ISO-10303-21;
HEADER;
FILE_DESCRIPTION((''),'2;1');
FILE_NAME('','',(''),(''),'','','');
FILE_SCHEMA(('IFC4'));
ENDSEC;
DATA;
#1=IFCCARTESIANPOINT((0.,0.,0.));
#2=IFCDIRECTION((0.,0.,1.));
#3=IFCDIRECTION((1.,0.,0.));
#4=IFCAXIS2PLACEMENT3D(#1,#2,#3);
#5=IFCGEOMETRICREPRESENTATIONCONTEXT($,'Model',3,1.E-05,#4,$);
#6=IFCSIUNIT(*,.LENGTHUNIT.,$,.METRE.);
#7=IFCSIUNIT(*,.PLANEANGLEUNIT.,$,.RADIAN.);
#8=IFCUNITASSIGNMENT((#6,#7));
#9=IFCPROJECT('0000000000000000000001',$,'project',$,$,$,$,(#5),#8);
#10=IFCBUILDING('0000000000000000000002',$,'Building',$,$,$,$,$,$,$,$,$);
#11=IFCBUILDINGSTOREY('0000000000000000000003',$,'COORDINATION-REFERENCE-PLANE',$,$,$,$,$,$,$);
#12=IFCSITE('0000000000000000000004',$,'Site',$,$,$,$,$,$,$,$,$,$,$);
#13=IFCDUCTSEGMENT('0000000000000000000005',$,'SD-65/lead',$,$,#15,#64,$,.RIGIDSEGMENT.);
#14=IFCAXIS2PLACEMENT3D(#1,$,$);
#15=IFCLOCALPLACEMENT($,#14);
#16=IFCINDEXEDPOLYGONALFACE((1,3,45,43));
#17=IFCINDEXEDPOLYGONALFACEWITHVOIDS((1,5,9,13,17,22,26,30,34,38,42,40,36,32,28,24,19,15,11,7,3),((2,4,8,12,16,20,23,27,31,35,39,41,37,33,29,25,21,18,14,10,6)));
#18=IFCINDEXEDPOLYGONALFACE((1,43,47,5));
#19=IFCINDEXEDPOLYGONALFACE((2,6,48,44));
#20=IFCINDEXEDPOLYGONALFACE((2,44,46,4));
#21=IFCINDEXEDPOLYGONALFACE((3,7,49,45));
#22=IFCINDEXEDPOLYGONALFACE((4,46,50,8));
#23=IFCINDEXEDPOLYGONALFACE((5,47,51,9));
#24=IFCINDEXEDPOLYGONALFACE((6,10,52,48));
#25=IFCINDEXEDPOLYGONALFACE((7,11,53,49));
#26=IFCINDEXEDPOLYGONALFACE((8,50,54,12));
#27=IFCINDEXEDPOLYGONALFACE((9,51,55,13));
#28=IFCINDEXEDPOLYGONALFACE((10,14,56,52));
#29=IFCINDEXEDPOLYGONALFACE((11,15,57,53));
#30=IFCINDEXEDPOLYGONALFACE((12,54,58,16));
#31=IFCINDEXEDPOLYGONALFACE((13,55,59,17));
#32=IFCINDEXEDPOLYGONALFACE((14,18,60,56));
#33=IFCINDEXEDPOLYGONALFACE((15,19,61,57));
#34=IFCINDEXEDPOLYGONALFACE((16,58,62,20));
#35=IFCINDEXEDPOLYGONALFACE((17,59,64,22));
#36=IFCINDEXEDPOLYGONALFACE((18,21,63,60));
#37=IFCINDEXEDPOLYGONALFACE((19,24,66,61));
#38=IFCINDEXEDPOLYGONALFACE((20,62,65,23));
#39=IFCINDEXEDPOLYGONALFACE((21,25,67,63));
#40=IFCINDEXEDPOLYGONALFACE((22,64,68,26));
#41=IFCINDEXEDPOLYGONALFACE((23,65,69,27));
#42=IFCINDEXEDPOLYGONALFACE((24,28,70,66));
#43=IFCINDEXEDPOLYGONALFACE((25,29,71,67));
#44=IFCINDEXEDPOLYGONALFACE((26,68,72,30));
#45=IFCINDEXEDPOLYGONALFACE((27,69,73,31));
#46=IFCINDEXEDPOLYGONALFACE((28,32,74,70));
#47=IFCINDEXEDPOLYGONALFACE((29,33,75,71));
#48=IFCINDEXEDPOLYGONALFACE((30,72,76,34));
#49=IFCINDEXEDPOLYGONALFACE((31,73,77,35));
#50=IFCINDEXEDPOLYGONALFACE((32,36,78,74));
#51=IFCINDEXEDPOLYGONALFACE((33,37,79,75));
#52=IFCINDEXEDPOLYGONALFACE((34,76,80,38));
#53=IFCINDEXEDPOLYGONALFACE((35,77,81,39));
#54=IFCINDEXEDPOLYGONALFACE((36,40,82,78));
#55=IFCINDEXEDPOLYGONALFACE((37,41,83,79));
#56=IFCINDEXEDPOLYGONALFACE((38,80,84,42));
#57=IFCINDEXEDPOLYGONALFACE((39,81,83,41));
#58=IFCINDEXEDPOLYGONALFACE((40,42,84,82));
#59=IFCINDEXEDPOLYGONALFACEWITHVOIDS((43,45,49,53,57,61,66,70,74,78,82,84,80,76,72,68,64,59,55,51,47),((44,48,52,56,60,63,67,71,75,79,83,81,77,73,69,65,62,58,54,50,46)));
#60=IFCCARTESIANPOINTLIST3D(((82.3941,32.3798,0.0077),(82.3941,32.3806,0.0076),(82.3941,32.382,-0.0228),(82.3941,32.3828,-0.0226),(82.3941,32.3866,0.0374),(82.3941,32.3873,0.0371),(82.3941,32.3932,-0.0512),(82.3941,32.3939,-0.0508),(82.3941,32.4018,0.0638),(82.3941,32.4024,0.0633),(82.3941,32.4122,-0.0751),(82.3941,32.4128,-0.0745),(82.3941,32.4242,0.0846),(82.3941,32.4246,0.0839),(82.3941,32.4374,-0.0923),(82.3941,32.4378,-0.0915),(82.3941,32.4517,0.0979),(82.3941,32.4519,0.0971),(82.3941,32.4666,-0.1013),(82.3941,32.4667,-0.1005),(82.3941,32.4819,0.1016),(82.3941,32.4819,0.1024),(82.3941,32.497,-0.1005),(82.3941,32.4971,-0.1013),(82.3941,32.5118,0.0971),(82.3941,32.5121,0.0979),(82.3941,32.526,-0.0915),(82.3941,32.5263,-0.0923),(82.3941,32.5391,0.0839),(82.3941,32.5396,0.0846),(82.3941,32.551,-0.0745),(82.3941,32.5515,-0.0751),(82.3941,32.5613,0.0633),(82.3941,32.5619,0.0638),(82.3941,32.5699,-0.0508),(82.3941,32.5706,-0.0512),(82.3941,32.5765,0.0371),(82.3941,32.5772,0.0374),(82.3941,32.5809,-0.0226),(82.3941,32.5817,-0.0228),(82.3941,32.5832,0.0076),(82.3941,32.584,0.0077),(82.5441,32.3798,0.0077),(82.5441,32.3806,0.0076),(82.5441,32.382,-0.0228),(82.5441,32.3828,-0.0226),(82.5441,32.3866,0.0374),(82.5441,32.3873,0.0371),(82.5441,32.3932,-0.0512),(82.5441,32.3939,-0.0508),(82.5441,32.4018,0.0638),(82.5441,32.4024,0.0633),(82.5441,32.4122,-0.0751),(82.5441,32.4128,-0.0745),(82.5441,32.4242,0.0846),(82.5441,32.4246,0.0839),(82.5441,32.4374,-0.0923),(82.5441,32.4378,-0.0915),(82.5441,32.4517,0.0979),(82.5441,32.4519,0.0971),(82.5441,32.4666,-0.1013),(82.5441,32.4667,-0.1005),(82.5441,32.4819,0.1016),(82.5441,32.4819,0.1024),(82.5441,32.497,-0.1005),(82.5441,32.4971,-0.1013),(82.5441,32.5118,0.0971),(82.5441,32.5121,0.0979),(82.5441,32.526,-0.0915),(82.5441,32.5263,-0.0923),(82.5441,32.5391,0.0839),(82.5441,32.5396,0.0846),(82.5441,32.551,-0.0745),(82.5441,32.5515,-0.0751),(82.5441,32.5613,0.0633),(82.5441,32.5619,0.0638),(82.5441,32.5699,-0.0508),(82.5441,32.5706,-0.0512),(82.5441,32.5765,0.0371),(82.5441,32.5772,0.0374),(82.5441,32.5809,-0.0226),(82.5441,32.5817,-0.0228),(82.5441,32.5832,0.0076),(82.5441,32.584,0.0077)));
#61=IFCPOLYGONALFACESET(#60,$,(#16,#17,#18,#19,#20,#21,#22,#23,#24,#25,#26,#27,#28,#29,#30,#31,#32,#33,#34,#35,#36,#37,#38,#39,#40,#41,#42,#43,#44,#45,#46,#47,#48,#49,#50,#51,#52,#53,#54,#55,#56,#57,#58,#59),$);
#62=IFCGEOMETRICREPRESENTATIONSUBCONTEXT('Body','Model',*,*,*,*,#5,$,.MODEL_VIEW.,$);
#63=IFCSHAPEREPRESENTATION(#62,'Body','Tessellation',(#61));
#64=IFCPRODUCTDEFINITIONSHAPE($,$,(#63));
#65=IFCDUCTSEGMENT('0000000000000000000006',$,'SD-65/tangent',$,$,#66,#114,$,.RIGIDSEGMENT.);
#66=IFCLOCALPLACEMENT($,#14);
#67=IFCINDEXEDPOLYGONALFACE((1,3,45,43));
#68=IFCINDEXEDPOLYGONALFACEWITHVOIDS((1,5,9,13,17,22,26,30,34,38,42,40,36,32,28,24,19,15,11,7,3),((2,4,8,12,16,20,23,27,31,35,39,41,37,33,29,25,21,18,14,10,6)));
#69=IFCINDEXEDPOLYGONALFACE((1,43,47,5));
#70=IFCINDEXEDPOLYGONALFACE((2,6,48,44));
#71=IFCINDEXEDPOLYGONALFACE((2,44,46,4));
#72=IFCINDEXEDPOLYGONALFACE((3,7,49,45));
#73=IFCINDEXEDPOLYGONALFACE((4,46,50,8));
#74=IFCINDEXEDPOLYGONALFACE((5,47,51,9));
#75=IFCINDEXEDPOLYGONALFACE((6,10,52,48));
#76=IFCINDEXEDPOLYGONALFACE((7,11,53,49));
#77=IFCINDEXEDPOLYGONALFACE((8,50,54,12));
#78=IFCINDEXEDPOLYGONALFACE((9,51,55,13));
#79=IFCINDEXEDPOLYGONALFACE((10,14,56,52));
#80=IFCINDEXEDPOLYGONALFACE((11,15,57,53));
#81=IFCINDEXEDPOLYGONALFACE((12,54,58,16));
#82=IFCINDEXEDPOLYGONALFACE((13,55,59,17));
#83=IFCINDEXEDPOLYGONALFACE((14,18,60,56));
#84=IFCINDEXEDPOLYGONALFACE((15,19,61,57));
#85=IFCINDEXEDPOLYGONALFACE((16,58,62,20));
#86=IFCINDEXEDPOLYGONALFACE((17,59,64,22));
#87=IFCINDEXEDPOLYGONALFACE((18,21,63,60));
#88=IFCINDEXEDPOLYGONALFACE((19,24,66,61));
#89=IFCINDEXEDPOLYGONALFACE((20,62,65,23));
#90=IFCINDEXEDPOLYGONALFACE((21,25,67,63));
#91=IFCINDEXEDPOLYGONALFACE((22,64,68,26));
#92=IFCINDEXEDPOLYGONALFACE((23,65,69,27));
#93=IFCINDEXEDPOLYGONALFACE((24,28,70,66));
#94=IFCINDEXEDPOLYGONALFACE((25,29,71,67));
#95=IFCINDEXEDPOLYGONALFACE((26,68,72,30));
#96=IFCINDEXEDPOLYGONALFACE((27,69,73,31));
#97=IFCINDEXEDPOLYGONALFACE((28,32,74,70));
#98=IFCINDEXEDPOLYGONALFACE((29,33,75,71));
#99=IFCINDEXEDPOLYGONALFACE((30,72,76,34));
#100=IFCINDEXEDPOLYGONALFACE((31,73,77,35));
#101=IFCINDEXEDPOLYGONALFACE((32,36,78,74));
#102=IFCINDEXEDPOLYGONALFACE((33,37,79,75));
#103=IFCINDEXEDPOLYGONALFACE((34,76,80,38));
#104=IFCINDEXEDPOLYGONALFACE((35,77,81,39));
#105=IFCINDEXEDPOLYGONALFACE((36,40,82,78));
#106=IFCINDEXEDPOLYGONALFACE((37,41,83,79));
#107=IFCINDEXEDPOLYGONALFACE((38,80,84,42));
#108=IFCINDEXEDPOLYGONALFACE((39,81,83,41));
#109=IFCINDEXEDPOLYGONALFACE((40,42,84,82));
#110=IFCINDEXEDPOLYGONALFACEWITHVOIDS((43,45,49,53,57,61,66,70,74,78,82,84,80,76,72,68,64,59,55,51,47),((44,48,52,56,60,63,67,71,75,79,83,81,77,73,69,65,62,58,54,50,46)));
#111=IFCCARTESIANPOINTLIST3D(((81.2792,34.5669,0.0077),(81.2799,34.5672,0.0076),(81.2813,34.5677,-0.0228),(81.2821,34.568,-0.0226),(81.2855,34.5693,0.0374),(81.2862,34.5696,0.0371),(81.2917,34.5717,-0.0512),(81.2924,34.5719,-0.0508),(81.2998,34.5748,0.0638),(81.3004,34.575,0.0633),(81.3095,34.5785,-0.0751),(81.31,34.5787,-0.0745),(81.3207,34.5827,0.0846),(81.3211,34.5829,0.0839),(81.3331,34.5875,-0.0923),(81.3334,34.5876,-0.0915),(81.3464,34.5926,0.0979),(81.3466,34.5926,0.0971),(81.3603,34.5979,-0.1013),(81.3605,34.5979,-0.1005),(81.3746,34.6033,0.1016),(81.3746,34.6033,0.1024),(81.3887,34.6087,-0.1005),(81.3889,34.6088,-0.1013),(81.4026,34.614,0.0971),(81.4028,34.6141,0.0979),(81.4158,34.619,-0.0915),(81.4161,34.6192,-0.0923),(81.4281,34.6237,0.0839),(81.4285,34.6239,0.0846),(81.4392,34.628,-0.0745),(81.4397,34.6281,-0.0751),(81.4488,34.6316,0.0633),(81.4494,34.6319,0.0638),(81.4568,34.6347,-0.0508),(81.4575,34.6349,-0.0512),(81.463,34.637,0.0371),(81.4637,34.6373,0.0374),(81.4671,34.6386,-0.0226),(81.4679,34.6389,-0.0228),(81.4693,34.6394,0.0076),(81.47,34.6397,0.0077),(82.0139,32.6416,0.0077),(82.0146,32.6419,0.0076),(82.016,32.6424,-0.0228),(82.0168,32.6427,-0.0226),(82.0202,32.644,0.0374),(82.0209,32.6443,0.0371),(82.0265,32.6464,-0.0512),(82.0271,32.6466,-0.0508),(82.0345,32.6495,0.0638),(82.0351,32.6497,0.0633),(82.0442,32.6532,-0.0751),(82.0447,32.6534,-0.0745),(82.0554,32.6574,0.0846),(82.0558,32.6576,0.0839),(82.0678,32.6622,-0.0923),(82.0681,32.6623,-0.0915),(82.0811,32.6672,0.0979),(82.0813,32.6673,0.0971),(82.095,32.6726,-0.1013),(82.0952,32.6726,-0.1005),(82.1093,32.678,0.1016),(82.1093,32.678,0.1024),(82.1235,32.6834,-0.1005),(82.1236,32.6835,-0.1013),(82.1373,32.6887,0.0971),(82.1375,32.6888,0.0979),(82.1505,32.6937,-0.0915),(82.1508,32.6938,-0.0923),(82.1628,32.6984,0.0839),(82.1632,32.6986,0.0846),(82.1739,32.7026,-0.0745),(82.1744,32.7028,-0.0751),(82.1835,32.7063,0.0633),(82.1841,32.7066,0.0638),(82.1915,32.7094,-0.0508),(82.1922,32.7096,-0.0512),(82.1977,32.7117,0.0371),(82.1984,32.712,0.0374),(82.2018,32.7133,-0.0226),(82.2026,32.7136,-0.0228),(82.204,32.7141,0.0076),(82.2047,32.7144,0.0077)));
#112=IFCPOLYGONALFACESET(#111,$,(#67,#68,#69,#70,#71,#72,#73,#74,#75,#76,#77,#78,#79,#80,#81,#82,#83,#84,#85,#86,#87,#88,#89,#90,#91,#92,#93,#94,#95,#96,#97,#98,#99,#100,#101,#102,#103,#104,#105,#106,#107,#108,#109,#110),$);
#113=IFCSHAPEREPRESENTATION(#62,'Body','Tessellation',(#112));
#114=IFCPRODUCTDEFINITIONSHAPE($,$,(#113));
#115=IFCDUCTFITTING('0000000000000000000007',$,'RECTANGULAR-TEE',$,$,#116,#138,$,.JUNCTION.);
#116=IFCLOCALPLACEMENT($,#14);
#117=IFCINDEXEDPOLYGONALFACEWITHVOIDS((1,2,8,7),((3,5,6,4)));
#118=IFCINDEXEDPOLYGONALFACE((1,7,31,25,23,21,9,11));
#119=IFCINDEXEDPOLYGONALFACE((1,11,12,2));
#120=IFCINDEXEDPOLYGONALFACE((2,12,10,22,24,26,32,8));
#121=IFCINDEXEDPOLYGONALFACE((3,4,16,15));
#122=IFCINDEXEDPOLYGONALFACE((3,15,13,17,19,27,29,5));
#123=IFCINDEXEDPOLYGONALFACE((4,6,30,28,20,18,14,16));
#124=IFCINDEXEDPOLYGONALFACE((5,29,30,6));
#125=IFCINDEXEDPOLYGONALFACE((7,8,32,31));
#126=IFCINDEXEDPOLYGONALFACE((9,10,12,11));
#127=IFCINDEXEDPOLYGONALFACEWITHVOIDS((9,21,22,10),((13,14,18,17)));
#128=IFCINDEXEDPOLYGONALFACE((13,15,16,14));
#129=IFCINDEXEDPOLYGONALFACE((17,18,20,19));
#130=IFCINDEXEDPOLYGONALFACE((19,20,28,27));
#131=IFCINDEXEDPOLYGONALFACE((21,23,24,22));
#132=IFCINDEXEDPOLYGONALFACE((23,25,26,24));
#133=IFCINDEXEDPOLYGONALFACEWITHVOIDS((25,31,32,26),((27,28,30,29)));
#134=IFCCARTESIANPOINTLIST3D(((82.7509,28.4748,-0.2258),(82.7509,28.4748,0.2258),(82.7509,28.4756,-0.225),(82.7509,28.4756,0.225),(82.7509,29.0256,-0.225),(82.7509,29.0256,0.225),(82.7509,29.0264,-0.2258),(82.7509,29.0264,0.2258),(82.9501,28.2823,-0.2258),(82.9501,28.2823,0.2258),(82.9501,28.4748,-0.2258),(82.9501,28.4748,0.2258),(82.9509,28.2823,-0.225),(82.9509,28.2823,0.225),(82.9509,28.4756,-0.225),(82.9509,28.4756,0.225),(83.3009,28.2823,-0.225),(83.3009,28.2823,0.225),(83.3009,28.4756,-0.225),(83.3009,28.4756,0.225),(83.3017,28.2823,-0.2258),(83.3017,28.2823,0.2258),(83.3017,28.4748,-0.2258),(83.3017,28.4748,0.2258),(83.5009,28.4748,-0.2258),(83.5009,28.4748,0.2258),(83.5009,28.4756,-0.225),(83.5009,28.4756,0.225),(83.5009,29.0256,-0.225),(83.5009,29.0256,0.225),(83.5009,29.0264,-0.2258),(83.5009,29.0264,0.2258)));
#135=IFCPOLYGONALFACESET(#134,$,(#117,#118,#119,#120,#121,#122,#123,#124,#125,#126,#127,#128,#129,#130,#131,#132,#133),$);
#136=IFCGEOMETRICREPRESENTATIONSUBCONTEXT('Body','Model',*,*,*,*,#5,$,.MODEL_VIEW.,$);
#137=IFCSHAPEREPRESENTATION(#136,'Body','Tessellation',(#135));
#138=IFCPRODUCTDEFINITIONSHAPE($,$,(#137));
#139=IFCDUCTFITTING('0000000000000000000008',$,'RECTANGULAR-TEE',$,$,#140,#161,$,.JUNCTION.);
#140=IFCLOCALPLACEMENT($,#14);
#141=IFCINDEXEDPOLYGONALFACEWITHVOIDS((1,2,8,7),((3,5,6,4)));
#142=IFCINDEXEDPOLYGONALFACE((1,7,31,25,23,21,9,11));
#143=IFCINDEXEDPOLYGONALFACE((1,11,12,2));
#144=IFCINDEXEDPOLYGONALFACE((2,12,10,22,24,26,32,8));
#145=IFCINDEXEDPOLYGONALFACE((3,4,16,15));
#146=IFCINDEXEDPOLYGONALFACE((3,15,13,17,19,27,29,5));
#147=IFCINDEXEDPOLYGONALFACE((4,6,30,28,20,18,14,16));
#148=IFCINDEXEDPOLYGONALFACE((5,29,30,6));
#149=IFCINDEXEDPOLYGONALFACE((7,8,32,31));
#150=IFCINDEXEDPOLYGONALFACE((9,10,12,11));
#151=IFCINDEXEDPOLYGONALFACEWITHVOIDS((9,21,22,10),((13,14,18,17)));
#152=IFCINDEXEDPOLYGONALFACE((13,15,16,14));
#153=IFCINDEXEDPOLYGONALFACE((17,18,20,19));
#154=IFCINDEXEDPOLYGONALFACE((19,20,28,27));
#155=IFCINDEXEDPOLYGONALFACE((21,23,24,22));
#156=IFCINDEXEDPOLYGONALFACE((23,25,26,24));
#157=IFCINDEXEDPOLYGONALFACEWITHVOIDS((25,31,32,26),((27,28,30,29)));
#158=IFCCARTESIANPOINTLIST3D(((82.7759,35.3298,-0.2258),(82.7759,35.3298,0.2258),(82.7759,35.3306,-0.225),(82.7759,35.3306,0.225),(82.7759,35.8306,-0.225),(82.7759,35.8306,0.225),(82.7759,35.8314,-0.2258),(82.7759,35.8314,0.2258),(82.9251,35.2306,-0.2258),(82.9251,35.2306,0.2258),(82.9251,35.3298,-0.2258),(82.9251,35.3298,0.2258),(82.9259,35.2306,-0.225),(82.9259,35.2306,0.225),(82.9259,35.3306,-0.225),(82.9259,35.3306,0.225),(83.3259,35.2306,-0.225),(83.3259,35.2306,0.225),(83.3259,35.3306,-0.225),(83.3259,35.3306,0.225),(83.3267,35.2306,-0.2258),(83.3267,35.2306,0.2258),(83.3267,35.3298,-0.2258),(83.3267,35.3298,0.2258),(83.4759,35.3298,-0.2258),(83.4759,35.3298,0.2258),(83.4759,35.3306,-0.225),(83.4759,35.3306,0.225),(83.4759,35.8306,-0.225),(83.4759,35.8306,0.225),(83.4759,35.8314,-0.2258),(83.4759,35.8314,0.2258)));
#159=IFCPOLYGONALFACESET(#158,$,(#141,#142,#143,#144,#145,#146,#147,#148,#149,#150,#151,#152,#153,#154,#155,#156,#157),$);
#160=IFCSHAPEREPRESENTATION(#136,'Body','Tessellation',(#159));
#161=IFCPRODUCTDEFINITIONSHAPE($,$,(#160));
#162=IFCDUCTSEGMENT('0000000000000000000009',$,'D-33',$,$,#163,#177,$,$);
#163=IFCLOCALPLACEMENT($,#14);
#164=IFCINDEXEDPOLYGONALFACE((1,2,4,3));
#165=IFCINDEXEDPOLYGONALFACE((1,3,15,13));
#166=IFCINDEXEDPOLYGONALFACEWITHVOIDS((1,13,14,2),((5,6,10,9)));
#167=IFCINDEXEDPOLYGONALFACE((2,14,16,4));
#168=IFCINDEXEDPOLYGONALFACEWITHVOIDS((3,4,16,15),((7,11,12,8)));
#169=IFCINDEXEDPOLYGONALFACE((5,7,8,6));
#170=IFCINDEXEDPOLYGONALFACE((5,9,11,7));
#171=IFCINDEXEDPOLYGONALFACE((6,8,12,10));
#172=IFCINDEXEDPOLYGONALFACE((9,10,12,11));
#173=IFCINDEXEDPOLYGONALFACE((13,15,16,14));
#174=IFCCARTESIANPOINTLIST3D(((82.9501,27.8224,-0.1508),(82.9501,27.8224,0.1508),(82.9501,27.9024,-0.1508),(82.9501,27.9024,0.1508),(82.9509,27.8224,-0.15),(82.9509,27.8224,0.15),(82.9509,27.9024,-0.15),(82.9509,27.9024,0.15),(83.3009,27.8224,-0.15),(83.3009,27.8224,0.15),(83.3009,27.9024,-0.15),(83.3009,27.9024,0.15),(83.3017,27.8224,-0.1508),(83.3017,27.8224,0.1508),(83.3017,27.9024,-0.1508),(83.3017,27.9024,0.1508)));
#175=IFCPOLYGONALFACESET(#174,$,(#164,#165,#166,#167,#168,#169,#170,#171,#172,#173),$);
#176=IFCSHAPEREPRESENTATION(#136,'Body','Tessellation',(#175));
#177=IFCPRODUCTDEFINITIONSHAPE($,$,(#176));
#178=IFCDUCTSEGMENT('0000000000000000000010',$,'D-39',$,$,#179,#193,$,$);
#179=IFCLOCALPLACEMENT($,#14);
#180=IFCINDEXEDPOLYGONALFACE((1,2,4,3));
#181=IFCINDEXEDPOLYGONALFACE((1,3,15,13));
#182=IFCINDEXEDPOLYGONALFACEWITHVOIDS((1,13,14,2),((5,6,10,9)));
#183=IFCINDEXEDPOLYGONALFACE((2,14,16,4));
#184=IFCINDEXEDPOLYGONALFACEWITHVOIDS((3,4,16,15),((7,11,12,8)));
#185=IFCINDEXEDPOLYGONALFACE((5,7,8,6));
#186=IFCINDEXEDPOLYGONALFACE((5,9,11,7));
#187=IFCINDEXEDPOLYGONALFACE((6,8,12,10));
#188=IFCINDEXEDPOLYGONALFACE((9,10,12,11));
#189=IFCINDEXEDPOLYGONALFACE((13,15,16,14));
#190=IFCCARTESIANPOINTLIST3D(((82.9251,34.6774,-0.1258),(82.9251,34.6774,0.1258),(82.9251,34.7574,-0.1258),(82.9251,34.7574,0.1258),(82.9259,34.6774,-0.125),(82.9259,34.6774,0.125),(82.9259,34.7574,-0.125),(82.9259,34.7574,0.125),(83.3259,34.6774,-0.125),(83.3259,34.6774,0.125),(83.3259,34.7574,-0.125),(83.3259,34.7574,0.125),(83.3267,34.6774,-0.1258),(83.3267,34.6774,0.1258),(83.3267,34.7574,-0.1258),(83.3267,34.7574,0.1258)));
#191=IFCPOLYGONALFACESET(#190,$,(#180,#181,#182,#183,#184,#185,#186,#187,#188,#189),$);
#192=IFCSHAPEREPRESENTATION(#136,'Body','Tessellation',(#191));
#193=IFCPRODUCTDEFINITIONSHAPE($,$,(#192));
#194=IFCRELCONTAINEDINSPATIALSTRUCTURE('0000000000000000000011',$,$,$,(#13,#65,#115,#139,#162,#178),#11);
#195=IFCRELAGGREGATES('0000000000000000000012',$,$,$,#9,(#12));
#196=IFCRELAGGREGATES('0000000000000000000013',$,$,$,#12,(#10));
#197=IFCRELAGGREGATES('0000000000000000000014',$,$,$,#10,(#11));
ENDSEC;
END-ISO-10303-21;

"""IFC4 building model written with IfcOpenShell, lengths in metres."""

from ifc_helpers import new_model, si_unit, frame, origin, origin_with_axes, place, context, subcontext, project, spatial, rectangle, hollow_rectangle, hollow_circle, extrude, boolean, element, save


model = new_model("IFC4")

# Units and contexts
model_context_1 = context("Model", 3, precision=1e-05, world=origin_with_axes())
body_context_1 = subcontext(model_context_1, "Body", "Model", "MODEL_VIEW")
body_context_2 = subcontext(model_context_1, "Body", "Model", "MODEL_VIEW")
ifc_project = project(units=[si_unit("LENGTHUNIT", "METRE"), si_unit("PLANEANGLEUNIT", "RADIAN")], contexts=[model_context_1])

# Site, building, storey
site = spatial("IfcSite", under=ifc_project, Name="Site")
building = spatial("IfcBuilding", under=site, Name="Building")
storey = spatial("IfcBuildingStorey", under=building, Name="COORDINATION-REFERENCE-PLANE")

# Duct segment
duct_segment_1_placement = place(None, frame((82.5441, 32.4819, 0.0), z_axis=(-1.0, 0.0, 0.0), x_axis=(0.0, 0.0, 1.0)))
element("IfcDuctSegment", 1, at=duct_segment_1_placement, inside=storey, Name="SD-65/lead", PredefinedType="RIGIDSEGMENT", context=body_context_1, shape_type="SweptSolid", body=[
    extrude(hollow_circle(Radius=0.1024, WallThickness=0.0008), origin_with_axes(), (0.0, 0.0, 1.0), 0.15),
])

# Duct segment
duct_segment_2_placement = place(None, frame((82.1093, 32.678, 0.0), z_axis=(-0.356527, 0.934285, 0.0), x_axis=(0.0, 0.0, 1.0)))
element("IfcDuctSegment", 2, at=duct_segment_2_placement, inside=storey, Name="SD-65/tangent", PredefinedType="RIGIDSEGMENT", context=body_context_1, shape_type="SweptSolid", body=[
    extrude(hollow_circle(Radius=0.1024, WallThickness=0.0008), origin_with_axes(), (0.0, 0.0, 1.0), 2.0607),
])

# Duct fittings
duct_fitting_1_placement = place(None, frame((83.1259, 28.7506, 0.0), z_axis=(-1.0, 0.0, 0.0), x_axis=(0.0, -1.0, 0.0)))
solid_1 = boolean("UNION", extrude(rectangle(XDim=0.55, YDim=0.45), frame((0.0, 0.0, -0.375), z_axis=(0.0, 0.0, 1.0), x_axis=(1.0, 0.0, 0.0)), (0.0, 0.0, 1.0), 0.75), extrude(rectangle(XDim=0.35, YDim=0.45), frame((0.0, 0.0, 0.0), z_axis=(1.0, 0.0, 0.0), x_axis=(0.0, 0.0, -1.0)), (0.0, 0.0, 1.0), 0.4683))
element("IfcDuctFitting", 3, at=duct_fitting_1_placement, inside=storey, Name="RECTANGULAR-TEE", PredefinedType="JUNCTION", context=body_context_2, shape_type="CSG", body=[
    boolean("DIFFERENCE", boolean("UNION", extrude(rectangle(XDim=0.5516, YDim=0.4516), frame((0.0, 0.0, -0.375), z_axis=(0.0, 0.0, 1.0), x_axis=(1.0, 0.0, 0.0)), (0.0, 0.0, 1.0), 0.75), extrude(rectangle(XDim=0.3516, YDim=0.4516), frame((0.0, 0.0, 0.0), z_axis=(1.0, 0.0, 0.0), x_axis=(0.0, 0.0, -1.0)), (0.0, 0.0, 1.0), 0.4683)), solid_1),
])
duct_fitting_2_placement = place(None, frame((83.1259, 35.5806, 0.0), z_axis=(-1.0, 0.0, 0.0), x_axis=(0.0, -1.0, 0.0)))
solid_2 = boolean("UNION", extrude(rectangle(XDim=0.5, YDim=0.45), frame((0.0, 0.0, -0.35), z_axis=(0.0, 0.0, 1.0), x_axis=(1.0, 0.0, 0.0)), (0.0, 0.0, 1.0), 0.7), extrude(rectangle(XDim=0.4, YDim=0.45), frame((0.0, 0.0, 0.0), z_axis=(1.0, 0.0, 0.0), x_axis=(0.0, 0.0, -1.0)), (0.0, 0.0, 1.0), 0.35))
element("IfcDuctFitting", 4, at=duct_fitting_2_placement, inside=storey, Name="RECTANGULAR-TEE", PredefinedType="JUNCTION", context=body_context_2, shape_type="CSG", body=[
    boolean("DIFFERENCE", boolean("UNION", extrude(rectangle(XDim=0.5016, YDim=0.4516), frame((0.0, 0.0, -0.35), z_axis=(0.0, 0.0, 1.0), x_axis=(1.0, 0.0, 0.0)), (0.0, 0.0, 1.0), 0.7), extrude(rectangle(XDim=0.4016, YDim=0.4516), frame((0.0, 0.0, 0.0), z_axis=(1.0, 0.0, 0.0), x_axis=(0.0, 0.0, -1.0)), (0.0, 0.0, 1.0), 0.35)), solid_2),
])

# Duct segments
duct_segment_3_placement = place(None, frame((83.1259, 27.8224, 0.0), z_axis=(0.0, 1.0, 0.0), x_axis=(1.0, 0.0, 0.0)))
element("IfcDuctSegment", 5, at=duct_segment_3_placement, inside=storey, Name="D-33", context=body_context_2, shape_type="SweptSolid", body=[
    extrude(hollow_rectangle(XDim=0.3516, YDim=0.3016, WallThickness=0.0008), origin(), (0.0, 0.0, 1.0), 0.08),
])
duct_segment_4_placement = place(None, frame((83.1259, 34.6774, 0.0), z_axis=(0.0, 1.0, 0.0), x_axis=(1.0, 0.0, 0.0)))
element("IfcDuctSegment", 6, at=duct_segment_4_placement, inside=storey, Name="D-39", context=body_context_2, shape_type="SweptSolid", body=[
    extrude(hollow_rectangle(XDim=0.4016, YDim=0.2516, WallThickness=0.0008), origin(), (0.0, 0.0, 1.0), 0.08),
])

save(model, "model.ifc")
